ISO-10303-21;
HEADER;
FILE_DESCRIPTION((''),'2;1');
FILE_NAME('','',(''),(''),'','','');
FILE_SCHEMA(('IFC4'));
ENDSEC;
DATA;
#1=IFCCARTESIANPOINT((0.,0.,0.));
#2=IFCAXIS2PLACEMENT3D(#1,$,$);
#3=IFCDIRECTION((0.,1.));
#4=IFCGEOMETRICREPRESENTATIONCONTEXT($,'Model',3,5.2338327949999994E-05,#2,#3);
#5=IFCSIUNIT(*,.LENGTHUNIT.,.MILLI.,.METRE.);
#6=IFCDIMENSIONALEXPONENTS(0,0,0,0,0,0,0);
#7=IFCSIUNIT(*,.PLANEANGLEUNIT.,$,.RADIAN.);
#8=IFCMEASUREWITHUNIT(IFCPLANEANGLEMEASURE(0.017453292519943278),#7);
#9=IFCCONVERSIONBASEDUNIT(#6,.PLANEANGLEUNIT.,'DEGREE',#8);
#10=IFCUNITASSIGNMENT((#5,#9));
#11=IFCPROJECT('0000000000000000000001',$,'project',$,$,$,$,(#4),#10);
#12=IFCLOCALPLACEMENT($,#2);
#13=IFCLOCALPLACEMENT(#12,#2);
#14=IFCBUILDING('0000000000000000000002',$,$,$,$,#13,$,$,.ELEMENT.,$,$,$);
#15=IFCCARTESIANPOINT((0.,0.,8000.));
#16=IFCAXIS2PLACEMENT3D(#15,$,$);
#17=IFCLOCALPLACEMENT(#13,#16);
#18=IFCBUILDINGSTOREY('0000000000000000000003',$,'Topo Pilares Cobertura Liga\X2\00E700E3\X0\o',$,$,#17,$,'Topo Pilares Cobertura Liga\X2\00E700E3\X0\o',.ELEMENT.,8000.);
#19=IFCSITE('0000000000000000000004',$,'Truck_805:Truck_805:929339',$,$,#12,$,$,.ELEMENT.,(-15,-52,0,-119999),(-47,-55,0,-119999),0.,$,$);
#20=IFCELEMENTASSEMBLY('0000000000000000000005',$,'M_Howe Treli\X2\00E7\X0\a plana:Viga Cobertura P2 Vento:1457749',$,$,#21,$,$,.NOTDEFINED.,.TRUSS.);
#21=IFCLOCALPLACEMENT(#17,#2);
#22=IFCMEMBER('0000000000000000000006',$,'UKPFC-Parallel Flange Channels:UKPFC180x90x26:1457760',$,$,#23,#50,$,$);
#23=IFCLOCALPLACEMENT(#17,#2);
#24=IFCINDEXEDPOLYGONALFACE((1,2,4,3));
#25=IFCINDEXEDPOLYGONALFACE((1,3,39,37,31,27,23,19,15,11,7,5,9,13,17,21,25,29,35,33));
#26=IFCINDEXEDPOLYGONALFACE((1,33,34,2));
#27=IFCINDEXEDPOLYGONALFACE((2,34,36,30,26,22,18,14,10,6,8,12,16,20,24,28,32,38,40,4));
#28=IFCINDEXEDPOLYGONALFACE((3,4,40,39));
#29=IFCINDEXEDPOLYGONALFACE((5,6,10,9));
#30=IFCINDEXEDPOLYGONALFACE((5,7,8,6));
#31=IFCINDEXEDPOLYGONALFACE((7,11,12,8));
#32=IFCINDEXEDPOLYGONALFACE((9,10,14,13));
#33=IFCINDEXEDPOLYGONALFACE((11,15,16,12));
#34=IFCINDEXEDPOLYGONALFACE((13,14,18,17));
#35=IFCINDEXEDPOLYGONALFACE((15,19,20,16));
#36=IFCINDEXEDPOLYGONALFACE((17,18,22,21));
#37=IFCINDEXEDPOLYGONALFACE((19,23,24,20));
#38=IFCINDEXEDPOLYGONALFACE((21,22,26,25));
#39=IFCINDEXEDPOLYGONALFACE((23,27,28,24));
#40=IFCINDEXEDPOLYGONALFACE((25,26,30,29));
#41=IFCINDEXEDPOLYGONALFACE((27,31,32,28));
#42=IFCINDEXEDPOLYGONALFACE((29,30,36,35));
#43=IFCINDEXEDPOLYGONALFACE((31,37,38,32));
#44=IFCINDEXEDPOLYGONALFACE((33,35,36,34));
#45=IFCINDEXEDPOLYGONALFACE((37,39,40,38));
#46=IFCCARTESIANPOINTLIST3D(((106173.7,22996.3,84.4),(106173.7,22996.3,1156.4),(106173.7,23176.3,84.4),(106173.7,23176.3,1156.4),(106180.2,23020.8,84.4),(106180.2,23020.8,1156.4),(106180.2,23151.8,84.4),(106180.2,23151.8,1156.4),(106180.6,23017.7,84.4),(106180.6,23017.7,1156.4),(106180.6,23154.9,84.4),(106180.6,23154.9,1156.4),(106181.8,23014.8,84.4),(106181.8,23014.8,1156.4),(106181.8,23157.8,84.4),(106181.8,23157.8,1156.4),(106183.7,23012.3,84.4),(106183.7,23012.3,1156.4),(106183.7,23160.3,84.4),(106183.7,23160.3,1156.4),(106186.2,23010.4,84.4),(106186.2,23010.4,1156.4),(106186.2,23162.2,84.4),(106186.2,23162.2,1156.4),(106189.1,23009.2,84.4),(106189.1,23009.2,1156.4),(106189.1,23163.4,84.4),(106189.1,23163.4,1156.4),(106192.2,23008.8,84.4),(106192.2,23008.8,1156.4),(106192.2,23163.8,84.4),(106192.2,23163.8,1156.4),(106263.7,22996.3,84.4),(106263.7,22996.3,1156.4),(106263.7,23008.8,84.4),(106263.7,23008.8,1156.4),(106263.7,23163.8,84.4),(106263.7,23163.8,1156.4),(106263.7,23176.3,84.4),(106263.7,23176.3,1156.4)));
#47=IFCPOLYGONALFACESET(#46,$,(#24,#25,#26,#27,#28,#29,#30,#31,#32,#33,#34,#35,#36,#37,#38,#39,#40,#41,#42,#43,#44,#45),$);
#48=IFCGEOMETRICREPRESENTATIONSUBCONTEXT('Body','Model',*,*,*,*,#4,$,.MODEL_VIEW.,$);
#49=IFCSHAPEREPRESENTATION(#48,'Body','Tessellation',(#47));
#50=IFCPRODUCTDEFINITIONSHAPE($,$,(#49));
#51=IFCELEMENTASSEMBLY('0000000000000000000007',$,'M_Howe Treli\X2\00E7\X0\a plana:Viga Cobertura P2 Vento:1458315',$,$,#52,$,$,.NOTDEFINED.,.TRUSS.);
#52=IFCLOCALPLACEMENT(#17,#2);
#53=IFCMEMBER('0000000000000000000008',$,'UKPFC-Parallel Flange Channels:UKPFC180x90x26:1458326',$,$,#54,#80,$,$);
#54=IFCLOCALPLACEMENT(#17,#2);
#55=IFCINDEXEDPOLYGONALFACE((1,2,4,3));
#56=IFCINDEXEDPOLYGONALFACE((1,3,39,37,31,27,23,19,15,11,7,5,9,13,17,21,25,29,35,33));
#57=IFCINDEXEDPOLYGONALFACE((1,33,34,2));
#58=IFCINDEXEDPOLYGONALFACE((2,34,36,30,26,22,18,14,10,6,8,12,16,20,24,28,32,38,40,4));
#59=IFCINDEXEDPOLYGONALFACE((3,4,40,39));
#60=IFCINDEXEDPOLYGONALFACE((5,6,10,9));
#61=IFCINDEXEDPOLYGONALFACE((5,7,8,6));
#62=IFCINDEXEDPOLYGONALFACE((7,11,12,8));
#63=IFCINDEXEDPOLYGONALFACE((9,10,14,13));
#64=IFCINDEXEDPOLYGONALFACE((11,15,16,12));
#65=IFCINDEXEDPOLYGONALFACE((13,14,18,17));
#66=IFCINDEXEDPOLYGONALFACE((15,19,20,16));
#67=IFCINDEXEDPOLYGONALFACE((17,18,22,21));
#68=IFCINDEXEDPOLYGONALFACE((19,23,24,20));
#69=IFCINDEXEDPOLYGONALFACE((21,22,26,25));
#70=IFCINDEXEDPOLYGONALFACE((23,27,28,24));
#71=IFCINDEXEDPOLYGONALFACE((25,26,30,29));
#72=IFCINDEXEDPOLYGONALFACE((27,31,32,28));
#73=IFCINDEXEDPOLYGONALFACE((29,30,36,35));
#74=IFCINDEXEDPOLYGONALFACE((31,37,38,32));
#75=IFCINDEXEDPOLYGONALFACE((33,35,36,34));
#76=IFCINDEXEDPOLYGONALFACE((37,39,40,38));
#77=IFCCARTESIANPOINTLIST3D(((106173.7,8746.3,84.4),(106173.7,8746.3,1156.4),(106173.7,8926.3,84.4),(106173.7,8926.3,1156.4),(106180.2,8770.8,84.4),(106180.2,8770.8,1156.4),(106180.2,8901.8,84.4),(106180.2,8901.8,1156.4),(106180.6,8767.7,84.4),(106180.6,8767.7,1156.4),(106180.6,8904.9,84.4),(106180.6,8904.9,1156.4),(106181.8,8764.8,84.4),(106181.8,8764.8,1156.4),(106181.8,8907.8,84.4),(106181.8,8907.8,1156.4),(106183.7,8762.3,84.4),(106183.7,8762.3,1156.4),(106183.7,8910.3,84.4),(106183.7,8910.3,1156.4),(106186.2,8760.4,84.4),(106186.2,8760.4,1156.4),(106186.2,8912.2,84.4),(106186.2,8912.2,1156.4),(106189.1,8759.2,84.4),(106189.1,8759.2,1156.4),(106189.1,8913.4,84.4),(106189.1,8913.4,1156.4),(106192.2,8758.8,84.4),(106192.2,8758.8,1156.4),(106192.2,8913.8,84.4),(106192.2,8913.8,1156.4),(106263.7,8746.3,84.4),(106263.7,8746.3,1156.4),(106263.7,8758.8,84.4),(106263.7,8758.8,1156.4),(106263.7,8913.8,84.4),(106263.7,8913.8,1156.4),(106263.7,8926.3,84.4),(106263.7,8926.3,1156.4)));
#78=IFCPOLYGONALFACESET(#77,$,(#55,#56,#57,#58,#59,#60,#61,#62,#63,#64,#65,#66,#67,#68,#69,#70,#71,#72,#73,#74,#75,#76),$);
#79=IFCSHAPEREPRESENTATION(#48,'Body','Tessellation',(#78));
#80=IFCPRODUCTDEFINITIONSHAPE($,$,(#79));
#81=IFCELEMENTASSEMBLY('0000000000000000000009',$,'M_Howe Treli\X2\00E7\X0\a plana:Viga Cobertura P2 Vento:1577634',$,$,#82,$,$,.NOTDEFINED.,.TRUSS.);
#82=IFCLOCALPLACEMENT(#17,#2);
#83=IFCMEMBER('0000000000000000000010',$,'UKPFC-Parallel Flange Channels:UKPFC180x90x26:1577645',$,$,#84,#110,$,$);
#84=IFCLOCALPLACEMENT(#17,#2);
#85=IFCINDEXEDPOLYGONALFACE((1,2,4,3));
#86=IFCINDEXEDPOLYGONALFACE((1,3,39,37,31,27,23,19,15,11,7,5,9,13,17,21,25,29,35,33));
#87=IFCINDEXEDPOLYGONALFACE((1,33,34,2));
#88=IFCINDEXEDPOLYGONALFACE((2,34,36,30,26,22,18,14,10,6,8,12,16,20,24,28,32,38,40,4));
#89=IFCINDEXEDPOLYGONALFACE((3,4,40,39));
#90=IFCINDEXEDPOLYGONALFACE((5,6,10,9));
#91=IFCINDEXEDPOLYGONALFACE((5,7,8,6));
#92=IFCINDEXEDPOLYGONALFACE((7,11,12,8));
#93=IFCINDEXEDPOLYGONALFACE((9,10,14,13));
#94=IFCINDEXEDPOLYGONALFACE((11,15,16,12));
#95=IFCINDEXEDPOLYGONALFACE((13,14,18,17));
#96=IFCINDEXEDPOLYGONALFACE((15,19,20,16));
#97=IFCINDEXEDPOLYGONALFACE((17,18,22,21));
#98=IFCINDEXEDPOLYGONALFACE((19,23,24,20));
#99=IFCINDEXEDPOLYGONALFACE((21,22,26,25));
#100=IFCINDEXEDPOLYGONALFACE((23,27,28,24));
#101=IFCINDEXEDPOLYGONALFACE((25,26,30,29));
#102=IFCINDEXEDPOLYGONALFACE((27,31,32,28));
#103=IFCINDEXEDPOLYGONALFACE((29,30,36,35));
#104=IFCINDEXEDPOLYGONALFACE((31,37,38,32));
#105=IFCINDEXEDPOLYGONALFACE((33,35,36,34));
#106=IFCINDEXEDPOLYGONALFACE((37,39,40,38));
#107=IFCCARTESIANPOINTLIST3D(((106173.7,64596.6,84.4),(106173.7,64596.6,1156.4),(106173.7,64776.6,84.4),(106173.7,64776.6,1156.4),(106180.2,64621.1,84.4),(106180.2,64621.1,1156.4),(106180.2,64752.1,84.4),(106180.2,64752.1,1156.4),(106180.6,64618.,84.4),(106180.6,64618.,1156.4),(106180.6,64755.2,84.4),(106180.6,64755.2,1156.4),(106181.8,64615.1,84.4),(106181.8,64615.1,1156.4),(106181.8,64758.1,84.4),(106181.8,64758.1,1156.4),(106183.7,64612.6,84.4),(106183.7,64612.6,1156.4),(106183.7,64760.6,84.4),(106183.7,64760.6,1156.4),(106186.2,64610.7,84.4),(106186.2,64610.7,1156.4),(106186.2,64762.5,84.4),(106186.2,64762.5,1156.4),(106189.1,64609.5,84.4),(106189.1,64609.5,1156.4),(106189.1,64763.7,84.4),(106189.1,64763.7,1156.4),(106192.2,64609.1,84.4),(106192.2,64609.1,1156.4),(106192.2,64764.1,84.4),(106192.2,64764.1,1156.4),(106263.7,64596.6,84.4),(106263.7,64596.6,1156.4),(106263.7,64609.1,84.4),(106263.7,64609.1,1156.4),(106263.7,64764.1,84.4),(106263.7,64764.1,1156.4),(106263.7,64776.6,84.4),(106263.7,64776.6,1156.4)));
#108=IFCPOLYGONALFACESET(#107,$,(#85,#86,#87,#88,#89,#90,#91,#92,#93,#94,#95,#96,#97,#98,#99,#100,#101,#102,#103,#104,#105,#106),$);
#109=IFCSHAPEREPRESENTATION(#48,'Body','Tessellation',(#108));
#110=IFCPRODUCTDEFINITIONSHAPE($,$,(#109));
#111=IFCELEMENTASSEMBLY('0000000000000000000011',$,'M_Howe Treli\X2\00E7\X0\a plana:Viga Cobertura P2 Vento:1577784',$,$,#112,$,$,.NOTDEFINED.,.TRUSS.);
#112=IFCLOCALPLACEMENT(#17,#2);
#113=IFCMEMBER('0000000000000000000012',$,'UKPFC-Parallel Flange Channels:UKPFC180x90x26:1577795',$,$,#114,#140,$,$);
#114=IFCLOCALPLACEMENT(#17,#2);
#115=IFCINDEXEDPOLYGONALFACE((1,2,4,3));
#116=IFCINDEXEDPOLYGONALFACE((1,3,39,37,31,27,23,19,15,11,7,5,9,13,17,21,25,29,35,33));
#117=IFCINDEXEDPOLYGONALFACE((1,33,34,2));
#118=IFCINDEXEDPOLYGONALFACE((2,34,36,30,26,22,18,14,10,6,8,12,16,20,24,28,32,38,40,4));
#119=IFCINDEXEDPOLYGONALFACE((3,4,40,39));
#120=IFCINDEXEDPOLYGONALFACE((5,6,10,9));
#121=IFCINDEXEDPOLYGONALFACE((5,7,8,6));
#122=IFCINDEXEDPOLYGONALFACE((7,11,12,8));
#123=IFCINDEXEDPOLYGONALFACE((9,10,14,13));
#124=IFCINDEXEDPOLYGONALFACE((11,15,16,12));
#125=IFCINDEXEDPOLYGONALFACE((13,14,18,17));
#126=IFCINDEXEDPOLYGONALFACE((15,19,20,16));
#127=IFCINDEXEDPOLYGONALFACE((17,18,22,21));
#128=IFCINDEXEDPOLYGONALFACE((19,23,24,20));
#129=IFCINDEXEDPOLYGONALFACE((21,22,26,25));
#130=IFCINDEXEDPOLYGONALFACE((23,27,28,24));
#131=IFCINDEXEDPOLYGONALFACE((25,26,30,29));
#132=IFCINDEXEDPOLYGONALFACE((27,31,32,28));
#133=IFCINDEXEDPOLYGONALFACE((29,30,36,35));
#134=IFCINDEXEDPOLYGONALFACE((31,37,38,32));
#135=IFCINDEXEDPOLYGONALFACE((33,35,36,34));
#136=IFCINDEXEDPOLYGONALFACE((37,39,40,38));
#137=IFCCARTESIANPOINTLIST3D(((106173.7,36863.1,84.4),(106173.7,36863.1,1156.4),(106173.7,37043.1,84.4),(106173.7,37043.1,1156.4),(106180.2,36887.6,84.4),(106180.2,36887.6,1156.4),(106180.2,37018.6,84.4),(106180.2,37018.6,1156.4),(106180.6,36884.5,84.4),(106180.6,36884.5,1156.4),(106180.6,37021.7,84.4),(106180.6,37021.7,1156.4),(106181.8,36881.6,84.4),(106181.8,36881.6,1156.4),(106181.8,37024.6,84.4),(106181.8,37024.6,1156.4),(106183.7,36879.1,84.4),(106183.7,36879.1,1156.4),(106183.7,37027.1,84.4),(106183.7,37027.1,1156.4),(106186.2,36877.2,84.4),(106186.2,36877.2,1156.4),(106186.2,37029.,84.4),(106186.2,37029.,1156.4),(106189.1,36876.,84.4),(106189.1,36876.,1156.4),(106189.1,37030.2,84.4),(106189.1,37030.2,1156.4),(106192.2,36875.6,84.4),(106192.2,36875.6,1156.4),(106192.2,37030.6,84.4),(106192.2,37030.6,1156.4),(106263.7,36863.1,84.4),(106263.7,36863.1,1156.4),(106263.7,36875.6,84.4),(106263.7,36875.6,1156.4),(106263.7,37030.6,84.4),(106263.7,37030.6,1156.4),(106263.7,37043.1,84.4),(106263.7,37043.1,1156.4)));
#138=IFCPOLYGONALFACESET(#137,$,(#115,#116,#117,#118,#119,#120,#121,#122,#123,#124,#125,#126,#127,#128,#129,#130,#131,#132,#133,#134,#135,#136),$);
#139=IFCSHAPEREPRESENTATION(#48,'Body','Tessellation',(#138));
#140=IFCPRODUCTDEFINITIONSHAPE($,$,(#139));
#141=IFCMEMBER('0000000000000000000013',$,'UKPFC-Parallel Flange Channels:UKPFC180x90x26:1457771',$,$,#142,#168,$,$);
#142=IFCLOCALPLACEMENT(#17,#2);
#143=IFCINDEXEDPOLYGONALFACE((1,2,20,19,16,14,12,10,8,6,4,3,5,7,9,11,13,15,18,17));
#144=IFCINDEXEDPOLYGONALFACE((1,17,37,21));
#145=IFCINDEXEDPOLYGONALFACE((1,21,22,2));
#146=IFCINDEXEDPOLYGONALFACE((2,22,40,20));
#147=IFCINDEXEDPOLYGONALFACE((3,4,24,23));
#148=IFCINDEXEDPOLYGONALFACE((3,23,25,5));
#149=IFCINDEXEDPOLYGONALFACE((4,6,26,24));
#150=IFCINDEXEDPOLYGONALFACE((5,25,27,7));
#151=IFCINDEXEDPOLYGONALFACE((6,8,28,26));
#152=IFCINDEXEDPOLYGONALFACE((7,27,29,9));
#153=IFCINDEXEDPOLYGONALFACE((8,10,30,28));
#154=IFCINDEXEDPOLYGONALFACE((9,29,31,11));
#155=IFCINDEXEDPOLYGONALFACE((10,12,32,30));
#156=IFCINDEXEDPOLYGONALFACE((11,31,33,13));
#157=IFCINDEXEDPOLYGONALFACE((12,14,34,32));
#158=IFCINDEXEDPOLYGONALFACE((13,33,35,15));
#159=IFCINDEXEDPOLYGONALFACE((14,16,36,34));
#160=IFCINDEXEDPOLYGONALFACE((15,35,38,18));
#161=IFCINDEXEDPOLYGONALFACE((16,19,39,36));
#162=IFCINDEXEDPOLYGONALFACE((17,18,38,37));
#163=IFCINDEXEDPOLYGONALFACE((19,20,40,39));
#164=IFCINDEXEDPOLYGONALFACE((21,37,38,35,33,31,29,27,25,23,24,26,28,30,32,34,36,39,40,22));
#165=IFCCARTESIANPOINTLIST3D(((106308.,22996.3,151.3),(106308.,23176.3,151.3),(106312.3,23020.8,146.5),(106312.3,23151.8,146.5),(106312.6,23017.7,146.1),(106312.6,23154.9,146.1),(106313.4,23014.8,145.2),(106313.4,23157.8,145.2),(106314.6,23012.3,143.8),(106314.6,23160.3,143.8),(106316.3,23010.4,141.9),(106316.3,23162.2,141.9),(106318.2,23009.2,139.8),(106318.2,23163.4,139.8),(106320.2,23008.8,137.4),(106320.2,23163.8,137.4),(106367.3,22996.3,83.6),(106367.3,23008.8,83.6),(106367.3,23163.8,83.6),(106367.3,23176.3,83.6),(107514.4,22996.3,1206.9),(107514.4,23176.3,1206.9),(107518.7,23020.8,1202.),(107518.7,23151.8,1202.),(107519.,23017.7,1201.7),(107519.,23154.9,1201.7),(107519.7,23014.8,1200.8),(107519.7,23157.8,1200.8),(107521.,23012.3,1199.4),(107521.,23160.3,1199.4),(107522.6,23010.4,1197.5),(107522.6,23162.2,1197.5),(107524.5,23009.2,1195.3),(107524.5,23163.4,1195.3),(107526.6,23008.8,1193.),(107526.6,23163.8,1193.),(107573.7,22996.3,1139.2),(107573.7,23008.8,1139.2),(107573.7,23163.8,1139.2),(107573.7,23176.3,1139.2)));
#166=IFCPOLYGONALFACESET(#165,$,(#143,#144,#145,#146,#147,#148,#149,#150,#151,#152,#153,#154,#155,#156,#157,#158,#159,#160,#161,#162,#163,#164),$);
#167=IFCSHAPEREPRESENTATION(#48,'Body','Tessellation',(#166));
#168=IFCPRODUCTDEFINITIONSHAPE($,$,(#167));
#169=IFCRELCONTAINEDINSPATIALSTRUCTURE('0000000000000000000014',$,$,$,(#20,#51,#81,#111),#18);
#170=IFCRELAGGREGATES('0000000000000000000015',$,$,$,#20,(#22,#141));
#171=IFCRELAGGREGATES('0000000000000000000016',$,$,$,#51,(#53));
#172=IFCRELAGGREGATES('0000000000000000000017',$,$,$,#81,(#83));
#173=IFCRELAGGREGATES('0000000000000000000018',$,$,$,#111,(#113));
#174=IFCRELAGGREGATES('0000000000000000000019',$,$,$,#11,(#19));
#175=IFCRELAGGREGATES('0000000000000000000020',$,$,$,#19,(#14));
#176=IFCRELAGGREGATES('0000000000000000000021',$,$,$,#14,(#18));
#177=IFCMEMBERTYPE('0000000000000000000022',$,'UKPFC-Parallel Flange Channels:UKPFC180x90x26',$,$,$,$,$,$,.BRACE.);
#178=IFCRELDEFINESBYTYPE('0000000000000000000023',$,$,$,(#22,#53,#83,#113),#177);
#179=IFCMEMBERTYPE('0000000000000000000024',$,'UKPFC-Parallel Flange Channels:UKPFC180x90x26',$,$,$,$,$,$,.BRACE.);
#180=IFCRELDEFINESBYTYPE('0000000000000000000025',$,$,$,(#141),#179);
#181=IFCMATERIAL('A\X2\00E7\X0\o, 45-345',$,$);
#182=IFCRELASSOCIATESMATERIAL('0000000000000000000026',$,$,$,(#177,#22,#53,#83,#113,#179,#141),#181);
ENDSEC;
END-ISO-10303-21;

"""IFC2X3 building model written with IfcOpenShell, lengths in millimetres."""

from ifc_helpers import new_model, entity, si_unit, converted_unit, direction, frame, frame_2d, origin, place, context, subcontext, project, spatial, polyline, circle_curve, parameter, trimmed, segment, composite_curve, outline, extrude, source, transform, mapped, material, type_object, type_shapes, element, aggregate, save


model = new_model("IFC2X3")

# Units and contexts
model_context = context("Model", 3, precision=5.2338327949999994e-05, world=origin(), true_north=direction((0.0, 1.0)))
body_context = subcontext(model_context, "Body", "Model", "MODEL_VIEW")
ifc_project = project(units=[si_unit("LENGTHUNIT", "METRE", prefix="MILLI"), converted_unit("PLANEANGLEUNIT", "DEGREE", entity("IfcPlaneAngleMeasure", 0.017453292519943278), si_unit("PLANEANGLEUNIT", "RADIAN"), dimensions=[0, 0, 0, 0, 0, 0, 0])], contexts=[model_context])

# Site, building, storey
site_placement = place(None, origin())
site = spatial("IfcSite", under=ifc_project, at=site_placement, Name="Truck_805:Truck_805:929339", CompositionType="ELEMENT", RefLatitude=(-15, -52, 0, -119999), RefLongitude=(-47, -55, 0, -119999), RefElevation=0.0)
building_placement = place(site_placement, origin())
building = spatial("IfcBuilding", under=site, at=building_placement, CompositionType="ELEMENT")
storey_placement = place(building_placement, frame((0.0, 0.0, 8000.0)))
storey = spatial("IfcBuildingStorey", under=building, at=storey_placement, Name="Topo Pilares Cobertura Ligação", LongName="Topo Pilares Cobertura Ligação", CompositionType="ELEMENT", Elevation=8000.0)

# Element assemblies, members
assembly_1_placement = place(storey_placement, origin())
assembly_1 = element("IfcElementAssembly", 1, at=assembly_1_placement, inside=storey, Name="M_Howe Treliça plana:Viga Cobertura P2 Vento:1457749", AssemblyPlace="NOTDEFINED", PredefinedType="TRUSS")
ifc_material_1 = material(Name="Aço, 45-345")
member_type_1 = type_object("IfcMemberType", Name="UKPFC-Parallel Flange Channels:UKPFC180x90x26", PredefinedType="BRACE", material=ifc_material_1)
shared_shape_1 = source(origin(), body_context, "Body", "SweptSolid", [
    extrude(outline(composite_curve([segment(polyline([(-90.0, -41.0), (90.0, -41.0)]), True, "CONTINUOUS"), segment(polyline([(90.0, -41.0), (90.0, 49.0)]), True, "CONTINUOUS"), segment(polyline([(90.0, 49.0), (77.5, 49.0)]), True, "CONTINUOUS"), segment(polyline([(77.5, 49.0), (77.5, -22.5)]), True, "CONTINUOUS"), segment(trimmed(circle_curve(frame_2d((65.5, -22.5), x_axis=(1.0, 0.0)), 12.0), [parameter(270.0)], [parameter(0.0)], True, "PARAMETER"), False, "CONTINUOUS"), segment(polyline([(65.5, -34.5), (-65.5, -34.5)]), True, "CONTINUOUS"), segment(trimmed(circle_curve(frame_2d((-65.5, -22.5), x_axis=(0.0, -1.0)), 12.0), [parameter(270.0)], [parameter(0.0)], True, "PARAMETER"), False, "CONTINUOUS"), segment(polyline([(-77.5, -22.5), (-77.5, 49.0)]), True, "CONTINUOUS"), segment(polyline([(-77.5, 49.0), (-90.0, 49.0)]), True, "CONTINUOUS"), segment(polyline([(-90.0, 49.0), (-90.0, -41.0)]), True, "CONTINUOUS")], self_intersect=False)), frame((-535.0, 9.3, 0.0), z_axis=(1.0, 0.0, 0.0), x_axis=(0.0, 0.0, -1.0)), (0.0, 0.0, 1.0), 1072.0),
])
type_shapes(member_type_1, [shared_shape_1])
member_1_placement = place(assembly_1_placement, frame((106205.4, 23086.3, 619.4), z_axis=(0.0, 1.0, 0.0), x_axis=(0.0, 0.0, 1.0)))
member_1 = element("IfcMember", 2, at=member_1_placement, type_object=member_type_1, material=ifc_material_1, Name="UKPFC-Parallel Flange Channels:UKPFC180x90x26:1457760", context=body_context, shape_type="MappedRepresentation", body=[
    mapped(shared_shape_1, transform((0.0, 0.0, 0.0), scale=1.0)),
])
assembly_2_placement = place(storey_placement, origin())
assembly_2 = element("IfcElementAssembly", 3, at=assembly_2_placement, inside=storey, Name="M_Howe Treliça plana:Viga Cobertura P2 Vento:1458315", AssemblyPlace="NOTDEFINED", PredefinedType="TRUSS")
member_2_placement = place(assembly_2_placement, frame((106205.4, 8836.3, 619.4), z_axis=(0.0, 1.0, 0.0), x_axis=(0.0, 0.0, 1.0)))
member_2 = element("IfcMember", 4, at=member_2_placement, type_object=member_type_1, material=ifc_material_1, Name="UKPFC-Parallel Flange Channels:UKPFC180x90x26:1458326", context=body_context, shape_type="MappedRepresentation", body=[
    mapped(shared_shape_1, transform((0.0, 0.0, 0.0), scale=1.0)),
])
assembly_3_placement = place(storey_placement, origin())
assembly_3 = element("IfcElementAssembly", 5, at=assembly_3_placement, inside=storey, Name="M_Howe Treliça plana:Viga Cobertura P2 Vento:1577634", AssemblyPlace="NOTDEFINED", PredefinedType="TRUSS")
member_3_placement = place(assembly_3_placement, frame((106205.4, 64686.6, 619.4), z_axis=(0.0, 1.0, 0.0), x_axis=(0.0, 0.0, 1.0)))
member_3 = element("IfcMember", 6, at=member_3_placement, type_object=member_type_1, material=ifc_material_1, Name="UKPFC-Parallel Flange Channels:UKPFC180x90x26:1577645", context=body_context, shape_type="MappedRepresentation", body=[
    mapped(shared_shape_1, transform((0.0, 0.0, 0.0), scale=1.0)),
])
assembly_4_placement = place(storey_placement, origin())
assembly_4 = element("IfcElementAssembly", 7, at=assembly_4_placement, inside=storey, Name="M_Howe Treliça plana:Viga Cobertura P2 Vento:1577784", AssemblyPlace="NOTDEFINED", PredefinedType="TRUSS")
member_4_placement = place(assembly_4_placement, frame((106205.4, 36953.1, 619.4), z_axis=(0.0, 1.0, 0.0), x_axis=(0.0, 0.0, 1.0)))
member_4 = element("IfcMember", 8, at=member_4_placement, type_object=member_type_1, material=ifc_material_1, Name="UKPFC-Parallel Flange Channels:UKPFC180x90x26:1577795", context=body_context, shape_type="MappedRepresentation", body=[
    mapped(shared_shape_1, transform((0.0, 0.0, 0.0), scale=1.0)),
])

# Member
member_type_2 = type_object("IfcMemberType", Name="UKPFC-Parallel Flange Channels:UKPFC180x90x26", PredefinedType="BRACE", material=ifc_material_1)
shared_shape_2 = source(origin(), body_context, "Body", "SweptSolid", [
    extrude(outline(composite_curve([segment(polyline([(-90.0, -41.0), (90.0, -41.0)]), True, "CONTINUOUS"), segment(polyline([(90.0, -41.0), (90.0, 49.0)]), True, "CONTINUOUS"), segment(polyline([(90.0, 49.0), (77.5, 49.0)]), True, "CONTINUOUS"), segment(polyline([(77.5, 49.0), (77.5, -22.5)]), True, "CONTINUOUS"), segment(trimmed(circle_curve(frame_2d((65.5, -22.5), x_axis=(1.0, 0.0)), 12.0), [parameter(270.0)], [parameter(0.0)], True, "PARAMETER"), False, "CONTINUOUS"), segment(polyline([(65.5, -34.5), (-65.5, -34.5)]), True, "CONTINUOUS"), segment(trimmed(circle_curve(frame_2d((-65.5, -22.5), x_axis=(0.0, -1.0)), 12.0), [parameter(270.0)], [parameter(0.0)], True, "PARAMETER"), False, "CONTINUOUS"), segment(polyline([(-77.5, -22.5), (-77.5, 49.0)]), True, "CONTINUOUS"), segment(polyline([(-77.5, 49.0), (-90.0, 49.0)]), True, "CONTINUOUS"), segment(polyline([(-90.0, 49.0), (-90.0, -41.0)]), True, "CONTINUOUS")], self_intersect=False)), frame((-785.0, 9.3, 0.0), z_axis=(1.0, 0.0, 0.0), x_axis=(0.0, 0.0, -1.0)), (0.0, 0.0, 1.0), 1603.0),
])
type_shapes(member_type_2, [shared_shape_2])
member_5_placement = place(assembly_1_placement, frame((106919.7, 23086.3, 644.4), z_axis=(0.0, 1.0, 0.0), x_axis=(0.752577, 0.0, 0.658505)))
member_5 = element("IfcMember", 9, at=member_5_placement, type_object=member_type_2, material=ifc_material_1, Name="UKPFC-Parallel Flange Channels:UKPFC180x90x26:1457771", context=body_context, shape_type="MappedRepresentation", body=[
    mapped(shared_shape_2, transform((0.0, 0.0, 0.0), scale=1.0)),
])
aggregate(assembly_1, [member_1, member_5])
aggregate(assembly_2, [member_2])
aggregate(assembly_3, [member_3])
aggregate(assembly_4, [member_4])

save(model, "model.ifc")
